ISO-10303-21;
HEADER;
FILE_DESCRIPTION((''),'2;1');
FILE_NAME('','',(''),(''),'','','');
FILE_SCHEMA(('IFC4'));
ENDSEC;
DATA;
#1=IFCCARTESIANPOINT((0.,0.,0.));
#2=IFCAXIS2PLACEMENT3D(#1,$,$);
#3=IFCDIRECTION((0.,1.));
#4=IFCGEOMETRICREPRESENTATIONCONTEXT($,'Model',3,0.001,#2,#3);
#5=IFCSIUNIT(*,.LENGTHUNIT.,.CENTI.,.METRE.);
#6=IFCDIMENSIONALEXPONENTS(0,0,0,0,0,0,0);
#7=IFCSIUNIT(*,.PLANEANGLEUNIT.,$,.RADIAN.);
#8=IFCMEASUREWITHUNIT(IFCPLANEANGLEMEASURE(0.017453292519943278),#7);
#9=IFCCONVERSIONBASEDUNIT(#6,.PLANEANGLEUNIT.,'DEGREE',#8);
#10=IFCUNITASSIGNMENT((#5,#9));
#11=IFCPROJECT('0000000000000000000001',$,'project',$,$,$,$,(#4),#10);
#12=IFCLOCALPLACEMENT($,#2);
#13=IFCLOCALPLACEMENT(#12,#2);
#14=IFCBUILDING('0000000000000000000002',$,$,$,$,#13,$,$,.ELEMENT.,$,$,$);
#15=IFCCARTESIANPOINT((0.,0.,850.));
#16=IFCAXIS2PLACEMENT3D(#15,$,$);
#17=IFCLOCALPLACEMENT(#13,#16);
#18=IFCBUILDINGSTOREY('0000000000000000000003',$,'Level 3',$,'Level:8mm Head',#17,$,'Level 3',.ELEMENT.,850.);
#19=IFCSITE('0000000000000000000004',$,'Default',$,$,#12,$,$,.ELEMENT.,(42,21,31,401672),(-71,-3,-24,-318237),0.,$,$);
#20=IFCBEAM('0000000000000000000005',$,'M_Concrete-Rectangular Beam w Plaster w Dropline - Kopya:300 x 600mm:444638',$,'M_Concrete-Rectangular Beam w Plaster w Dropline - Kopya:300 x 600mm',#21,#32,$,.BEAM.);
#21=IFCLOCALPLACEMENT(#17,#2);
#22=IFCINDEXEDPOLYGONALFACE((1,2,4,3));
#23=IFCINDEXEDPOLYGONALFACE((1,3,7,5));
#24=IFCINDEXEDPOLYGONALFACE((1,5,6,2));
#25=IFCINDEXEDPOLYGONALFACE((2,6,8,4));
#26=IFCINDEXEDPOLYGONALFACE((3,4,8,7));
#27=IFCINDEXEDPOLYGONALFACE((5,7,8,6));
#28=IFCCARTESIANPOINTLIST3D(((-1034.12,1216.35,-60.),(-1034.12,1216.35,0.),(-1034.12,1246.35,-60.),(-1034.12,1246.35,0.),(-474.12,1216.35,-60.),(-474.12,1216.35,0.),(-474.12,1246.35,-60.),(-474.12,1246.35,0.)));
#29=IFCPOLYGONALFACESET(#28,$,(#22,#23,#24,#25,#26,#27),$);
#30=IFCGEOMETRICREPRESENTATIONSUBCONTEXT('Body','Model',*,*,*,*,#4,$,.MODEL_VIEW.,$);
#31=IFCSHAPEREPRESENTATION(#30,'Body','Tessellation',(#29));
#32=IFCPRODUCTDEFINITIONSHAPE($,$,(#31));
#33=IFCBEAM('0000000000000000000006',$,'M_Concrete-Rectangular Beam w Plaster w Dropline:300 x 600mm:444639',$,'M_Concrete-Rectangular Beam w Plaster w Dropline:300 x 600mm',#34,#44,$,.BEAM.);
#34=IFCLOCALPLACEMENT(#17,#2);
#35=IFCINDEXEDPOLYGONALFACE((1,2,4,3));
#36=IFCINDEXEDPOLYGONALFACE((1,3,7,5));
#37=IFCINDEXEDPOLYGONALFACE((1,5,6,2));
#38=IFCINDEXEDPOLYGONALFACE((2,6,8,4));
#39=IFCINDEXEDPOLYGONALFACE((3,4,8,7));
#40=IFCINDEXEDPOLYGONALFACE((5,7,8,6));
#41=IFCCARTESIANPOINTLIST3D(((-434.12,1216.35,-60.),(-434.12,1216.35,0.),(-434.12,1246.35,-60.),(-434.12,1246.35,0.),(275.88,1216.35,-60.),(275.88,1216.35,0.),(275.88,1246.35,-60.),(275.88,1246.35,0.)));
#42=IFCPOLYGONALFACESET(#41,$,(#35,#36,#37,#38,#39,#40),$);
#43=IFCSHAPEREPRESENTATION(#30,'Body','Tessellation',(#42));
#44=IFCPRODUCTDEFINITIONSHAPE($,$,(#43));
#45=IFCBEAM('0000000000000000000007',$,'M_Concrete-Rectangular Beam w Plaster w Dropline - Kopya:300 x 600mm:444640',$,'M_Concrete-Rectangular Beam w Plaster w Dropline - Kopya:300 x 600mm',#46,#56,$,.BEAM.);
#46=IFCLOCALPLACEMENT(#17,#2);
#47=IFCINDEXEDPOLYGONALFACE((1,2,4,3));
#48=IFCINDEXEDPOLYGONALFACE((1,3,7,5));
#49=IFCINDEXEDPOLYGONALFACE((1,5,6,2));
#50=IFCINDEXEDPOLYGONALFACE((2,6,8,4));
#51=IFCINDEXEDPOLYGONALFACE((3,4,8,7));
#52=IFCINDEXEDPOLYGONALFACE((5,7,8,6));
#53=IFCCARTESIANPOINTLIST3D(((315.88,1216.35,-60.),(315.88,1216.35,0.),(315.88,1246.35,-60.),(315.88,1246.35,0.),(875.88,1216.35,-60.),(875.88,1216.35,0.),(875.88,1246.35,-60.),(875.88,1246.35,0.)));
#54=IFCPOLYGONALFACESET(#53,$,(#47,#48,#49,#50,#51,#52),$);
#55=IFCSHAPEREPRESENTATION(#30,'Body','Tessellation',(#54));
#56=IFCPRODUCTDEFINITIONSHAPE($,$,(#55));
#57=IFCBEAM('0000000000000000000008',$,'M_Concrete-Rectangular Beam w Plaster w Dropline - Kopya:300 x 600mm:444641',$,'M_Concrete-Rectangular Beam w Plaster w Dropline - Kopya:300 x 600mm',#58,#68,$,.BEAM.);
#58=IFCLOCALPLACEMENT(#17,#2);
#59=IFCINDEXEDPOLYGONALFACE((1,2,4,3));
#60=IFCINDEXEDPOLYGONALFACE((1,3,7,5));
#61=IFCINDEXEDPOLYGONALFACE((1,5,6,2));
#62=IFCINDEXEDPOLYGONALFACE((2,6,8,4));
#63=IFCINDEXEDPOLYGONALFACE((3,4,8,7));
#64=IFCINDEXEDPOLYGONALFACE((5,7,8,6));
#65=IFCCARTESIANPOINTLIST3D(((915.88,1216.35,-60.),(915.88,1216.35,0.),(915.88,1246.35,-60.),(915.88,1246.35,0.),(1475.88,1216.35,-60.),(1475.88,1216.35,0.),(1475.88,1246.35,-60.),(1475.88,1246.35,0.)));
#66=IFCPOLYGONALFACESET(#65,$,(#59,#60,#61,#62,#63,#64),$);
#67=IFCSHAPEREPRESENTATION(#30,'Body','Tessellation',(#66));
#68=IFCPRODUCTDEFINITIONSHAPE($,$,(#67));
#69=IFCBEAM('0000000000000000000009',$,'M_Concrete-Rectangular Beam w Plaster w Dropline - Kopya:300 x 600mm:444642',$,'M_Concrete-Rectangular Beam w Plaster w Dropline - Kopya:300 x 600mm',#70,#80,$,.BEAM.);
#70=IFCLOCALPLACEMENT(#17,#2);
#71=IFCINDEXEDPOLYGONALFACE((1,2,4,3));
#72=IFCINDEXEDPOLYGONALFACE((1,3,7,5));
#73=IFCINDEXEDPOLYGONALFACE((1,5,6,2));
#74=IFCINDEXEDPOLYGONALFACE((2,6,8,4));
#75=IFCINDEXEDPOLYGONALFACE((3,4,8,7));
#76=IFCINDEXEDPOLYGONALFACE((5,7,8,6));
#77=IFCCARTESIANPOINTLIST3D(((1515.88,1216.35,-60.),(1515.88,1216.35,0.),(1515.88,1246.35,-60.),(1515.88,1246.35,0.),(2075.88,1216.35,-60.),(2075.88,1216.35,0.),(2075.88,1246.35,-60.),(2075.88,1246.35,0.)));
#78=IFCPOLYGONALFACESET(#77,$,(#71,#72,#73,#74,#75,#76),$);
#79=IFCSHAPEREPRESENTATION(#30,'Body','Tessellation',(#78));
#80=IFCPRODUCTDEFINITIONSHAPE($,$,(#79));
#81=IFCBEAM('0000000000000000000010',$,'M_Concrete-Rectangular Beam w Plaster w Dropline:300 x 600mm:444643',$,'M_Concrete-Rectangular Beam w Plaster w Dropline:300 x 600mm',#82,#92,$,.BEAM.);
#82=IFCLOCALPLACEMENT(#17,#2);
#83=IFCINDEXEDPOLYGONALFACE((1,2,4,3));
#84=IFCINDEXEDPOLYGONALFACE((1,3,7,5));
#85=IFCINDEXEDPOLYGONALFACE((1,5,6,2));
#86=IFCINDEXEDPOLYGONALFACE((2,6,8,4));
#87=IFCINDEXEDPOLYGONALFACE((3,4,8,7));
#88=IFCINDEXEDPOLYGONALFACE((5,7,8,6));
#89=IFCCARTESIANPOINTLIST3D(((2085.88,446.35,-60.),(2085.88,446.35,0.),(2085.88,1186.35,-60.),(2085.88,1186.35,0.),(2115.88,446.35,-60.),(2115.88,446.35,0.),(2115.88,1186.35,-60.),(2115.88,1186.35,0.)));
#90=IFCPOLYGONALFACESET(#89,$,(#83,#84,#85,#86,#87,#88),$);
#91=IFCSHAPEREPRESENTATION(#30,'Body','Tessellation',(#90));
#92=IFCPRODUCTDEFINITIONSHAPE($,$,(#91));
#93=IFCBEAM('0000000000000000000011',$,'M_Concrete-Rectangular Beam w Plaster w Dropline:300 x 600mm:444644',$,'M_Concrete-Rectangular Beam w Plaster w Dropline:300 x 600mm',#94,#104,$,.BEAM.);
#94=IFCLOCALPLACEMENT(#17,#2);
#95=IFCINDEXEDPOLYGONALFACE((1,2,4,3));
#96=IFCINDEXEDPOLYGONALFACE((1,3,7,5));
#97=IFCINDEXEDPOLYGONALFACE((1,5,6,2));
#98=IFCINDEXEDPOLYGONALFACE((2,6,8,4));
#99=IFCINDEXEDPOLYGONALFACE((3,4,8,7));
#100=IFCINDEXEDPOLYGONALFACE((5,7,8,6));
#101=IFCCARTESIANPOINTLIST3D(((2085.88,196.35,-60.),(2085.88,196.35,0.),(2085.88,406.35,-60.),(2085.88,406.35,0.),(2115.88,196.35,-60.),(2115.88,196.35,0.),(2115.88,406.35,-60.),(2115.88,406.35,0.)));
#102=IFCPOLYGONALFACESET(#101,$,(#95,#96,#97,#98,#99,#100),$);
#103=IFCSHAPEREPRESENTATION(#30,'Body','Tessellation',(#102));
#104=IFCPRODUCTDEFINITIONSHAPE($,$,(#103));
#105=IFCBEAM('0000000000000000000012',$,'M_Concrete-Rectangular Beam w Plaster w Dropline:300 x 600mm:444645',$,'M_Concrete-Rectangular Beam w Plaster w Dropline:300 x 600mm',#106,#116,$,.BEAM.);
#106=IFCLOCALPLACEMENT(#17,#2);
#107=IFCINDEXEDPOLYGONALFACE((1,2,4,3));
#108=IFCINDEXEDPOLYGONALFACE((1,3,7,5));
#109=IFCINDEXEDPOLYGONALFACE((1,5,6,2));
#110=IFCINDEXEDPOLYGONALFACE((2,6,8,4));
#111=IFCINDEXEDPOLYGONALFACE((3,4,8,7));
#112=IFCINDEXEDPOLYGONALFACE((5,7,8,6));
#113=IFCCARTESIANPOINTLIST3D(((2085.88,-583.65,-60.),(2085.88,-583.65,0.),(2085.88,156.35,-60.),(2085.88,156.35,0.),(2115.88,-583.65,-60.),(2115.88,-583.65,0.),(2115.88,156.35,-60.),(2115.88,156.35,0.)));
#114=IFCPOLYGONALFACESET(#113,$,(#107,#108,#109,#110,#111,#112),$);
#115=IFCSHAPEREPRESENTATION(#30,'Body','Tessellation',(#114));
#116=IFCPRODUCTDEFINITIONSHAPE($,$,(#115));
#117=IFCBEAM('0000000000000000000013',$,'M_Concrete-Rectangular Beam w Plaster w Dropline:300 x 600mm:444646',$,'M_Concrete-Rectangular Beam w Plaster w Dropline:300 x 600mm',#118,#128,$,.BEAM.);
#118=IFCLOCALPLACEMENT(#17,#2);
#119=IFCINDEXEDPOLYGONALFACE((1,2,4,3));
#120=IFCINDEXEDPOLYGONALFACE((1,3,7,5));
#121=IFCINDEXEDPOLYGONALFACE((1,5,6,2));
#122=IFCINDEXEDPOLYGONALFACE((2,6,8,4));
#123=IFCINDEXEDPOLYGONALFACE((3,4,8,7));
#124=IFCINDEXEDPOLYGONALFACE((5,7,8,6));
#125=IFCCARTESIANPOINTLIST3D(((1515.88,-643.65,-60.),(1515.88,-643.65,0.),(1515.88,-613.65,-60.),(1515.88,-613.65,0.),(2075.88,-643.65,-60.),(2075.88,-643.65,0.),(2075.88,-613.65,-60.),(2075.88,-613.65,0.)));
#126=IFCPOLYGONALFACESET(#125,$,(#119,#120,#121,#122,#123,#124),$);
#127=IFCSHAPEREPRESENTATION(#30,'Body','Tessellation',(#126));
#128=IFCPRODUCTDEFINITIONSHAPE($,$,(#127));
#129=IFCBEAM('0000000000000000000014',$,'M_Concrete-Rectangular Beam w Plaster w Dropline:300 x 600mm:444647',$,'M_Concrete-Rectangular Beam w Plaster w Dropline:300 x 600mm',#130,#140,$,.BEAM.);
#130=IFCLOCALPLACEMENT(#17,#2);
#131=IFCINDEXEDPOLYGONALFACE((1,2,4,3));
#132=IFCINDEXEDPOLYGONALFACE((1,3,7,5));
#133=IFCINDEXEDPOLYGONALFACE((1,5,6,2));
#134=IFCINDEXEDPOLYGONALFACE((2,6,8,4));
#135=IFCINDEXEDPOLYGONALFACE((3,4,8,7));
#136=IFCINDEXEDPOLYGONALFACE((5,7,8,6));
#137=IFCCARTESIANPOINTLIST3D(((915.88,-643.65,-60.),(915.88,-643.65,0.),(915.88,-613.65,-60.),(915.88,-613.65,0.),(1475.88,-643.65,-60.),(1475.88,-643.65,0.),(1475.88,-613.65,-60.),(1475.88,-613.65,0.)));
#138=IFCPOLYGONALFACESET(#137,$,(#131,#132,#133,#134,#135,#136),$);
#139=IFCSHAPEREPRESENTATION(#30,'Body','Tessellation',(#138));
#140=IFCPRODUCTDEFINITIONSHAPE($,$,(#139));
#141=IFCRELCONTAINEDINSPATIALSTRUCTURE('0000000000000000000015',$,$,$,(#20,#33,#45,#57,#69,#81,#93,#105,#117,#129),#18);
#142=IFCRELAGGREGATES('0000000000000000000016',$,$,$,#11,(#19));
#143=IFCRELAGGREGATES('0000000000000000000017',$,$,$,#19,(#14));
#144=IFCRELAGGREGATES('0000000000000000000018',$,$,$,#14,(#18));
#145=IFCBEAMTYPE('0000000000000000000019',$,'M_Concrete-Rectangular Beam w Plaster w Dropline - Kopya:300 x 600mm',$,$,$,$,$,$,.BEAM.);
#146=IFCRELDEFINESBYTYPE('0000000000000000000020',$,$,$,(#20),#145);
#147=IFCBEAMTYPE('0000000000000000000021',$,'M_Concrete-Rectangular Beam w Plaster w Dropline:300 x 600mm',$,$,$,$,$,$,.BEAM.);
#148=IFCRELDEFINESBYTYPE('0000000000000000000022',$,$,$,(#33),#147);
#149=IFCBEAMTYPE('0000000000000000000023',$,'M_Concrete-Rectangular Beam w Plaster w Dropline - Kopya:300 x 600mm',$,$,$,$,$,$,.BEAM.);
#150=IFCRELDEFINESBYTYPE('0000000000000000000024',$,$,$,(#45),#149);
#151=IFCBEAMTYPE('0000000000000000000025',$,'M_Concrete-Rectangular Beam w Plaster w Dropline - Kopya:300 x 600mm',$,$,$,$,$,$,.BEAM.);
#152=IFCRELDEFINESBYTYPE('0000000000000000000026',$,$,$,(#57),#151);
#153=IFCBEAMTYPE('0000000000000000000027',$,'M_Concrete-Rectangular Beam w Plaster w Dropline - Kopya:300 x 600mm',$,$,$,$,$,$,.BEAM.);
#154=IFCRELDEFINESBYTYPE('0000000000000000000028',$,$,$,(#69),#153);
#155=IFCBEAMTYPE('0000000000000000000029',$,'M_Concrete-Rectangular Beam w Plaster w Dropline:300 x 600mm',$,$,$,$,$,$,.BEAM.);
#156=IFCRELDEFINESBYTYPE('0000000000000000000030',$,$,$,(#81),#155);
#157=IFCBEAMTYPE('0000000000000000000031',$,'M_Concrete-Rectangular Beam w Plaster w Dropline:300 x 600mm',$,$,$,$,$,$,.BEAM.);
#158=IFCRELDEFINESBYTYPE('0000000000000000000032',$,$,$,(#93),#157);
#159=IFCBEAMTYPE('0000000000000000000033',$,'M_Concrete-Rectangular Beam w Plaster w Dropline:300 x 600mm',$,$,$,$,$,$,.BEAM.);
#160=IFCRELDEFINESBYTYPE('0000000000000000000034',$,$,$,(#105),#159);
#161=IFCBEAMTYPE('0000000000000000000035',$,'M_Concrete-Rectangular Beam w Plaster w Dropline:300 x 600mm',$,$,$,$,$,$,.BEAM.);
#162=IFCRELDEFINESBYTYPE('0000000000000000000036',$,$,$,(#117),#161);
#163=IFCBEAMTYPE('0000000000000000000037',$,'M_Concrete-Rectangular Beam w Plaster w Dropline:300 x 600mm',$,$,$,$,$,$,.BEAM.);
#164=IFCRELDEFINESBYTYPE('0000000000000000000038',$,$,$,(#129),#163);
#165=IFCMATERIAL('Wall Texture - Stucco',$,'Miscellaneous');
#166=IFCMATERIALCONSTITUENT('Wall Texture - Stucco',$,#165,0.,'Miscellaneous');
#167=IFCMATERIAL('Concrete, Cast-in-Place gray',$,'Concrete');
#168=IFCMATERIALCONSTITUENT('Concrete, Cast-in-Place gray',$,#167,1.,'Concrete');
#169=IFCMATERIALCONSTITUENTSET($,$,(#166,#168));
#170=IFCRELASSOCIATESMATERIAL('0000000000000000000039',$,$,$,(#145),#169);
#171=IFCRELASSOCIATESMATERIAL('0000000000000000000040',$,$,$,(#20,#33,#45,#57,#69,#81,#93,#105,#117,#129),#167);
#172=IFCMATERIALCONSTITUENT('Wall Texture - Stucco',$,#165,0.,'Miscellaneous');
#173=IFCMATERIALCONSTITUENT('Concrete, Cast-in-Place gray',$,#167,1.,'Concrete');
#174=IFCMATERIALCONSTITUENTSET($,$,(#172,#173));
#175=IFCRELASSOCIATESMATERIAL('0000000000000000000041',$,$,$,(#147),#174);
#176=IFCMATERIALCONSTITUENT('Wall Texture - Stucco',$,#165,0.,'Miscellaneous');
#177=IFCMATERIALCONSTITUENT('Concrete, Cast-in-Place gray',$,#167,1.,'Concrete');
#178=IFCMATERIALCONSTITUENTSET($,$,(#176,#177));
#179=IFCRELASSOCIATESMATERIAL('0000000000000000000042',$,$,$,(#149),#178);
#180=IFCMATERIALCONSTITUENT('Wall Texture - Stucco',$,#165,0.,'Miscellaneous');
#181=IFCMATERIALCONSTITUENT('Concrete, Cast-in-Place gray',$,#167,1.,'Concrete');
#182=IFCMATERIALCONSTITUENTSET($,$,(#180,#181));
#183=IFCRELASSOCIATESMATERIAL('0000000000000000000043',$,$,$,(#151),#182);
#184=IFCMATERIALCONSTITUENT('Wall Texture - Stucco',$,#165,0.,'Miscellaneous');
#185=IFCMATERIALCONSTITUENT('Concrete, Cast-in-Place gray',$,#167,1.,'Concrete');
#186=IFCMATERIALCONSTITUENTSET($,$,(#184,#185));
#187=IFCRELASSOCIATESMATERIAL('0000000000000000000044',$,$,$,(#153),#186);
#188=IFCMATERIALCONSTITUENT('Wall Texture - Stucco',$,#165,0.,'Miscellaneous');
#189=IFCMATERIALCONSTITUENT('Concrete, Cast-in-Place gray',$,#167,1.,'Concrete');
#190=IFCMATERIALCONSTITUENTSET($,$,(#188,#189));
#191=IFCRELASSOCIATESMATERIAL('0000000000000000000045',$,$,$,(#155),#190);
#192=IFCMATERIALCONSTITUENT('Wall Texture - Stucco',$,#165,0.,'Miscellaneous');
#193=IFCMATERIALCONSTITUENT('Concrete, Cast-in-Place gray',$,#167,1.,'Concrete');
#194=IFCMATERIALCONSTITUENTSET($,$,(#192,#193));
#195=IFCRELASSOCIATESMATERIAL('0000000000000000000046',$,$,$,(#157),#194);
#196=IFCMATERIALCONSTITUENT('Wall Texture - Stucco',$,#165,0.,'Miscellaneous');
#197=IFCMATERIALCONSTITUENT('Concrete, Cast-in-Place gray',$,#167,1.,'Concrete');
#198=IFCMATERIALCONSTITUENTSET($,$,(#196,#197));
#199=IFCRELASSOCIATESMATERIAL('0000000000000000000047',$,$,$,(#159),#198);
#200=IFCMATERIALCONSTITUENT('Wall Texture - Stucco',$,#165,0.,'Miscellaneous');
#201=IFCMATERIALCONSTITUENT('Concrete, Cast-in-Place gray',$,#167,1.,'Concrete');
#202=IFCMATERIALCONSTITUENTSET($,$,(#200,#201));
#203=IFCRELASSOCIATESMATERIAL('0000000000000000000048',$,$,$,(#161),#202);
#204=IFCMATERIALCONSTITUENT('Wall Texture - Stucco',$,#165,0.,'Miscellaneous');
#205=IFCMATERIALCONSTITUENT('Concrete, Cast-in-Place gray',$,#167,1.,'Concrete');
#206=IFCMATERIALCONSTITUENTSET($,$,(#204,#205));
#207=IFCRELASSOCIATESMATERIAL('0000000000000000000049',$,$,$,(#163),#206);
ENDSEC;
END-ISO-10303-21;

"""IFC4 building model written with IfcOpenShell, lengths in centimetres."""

from ifc_helpers import new_model, entity, si_unit, converted_unit, direction, frame, origin, place, context, subcontext, project, spatial, indexed_curve, outline, extrude, source, transform, mapped, material, constituent, constituent_set, type_object, type_shapes, element, save


model = new_model("IFC4")

# Units and contexts
model_context = context("Model", 3, precision=0.001, world=origin(), true_north=direction((0.0, 1.0)))
body_context = subcontext(model_context, "Body", "Model", "MODEL_VIEW")
ifc_project = project(units=[si_unit("LENGTHUNIT", "METRE", prefix="CENTI"), converted_unit("PLANEANGLEUNIT", "DEGREE", entity("IfcPlaneAngleMeasure", 0.017453292519943278), si_unit("PLANEANGLEUNIT", "RADIAN"), dimensions=[0, 0, 0, 0, 0, 0, 0])], contexts=[model_context])

# Site, building, storey
site_placement = place(None, origin())
site = spatial("IfcSite", under=ifc_project, at=site_placement, Name="Default", CompositionType="ELEMENT", RefLatitude=(42, 21, 31, 401672), RefLongitude=(-71, -3, -24, -318237), RefElevation=0.0)
building_placement = place(site_placement, origin())
building = spatial("IfcBuilding", under=site, at=building_placement, CompositionType="ELEMENT")
storey_placement = place(building_placement, frame((0.0, 0.0, 850.0)))
storey = spatial("IfcBuildingStorey", under=building, at=storey_placement, Name="Level 3", ObjectType="Level:8mm Head", LongName="Level 3", CompositionType="ELEMENT", Elevation=850.0)

# Beams
ifc_material_1 = material(Name="Concrete, Cast-in-Place gray", Category="Concrete")
ifc_material_2 = material(Name="Wall Texture - Stucco", Category="Miscellaneous")
ifc_constituent_1 = constituent(ifc_material_2, Name="Wall Texture - Stucco", Category="Miscellaneous", fraction=0.0)
ifc_constituent_2 = constituent(ifc_material_1, Name="Concrete, Cast-in-Place gray", Category="Concrete", fraction=1.0)
ifc_constituent_set_1 = constituent_set(constituents=[ifc_constituent_1, ifc_constituent_2])
beam_type_1 = type_object("IfcBeamType", Name="M_Concrete-Rectangular Beam w Plaster w Dropline - Kopya:300 x 600mm", PredefinedType="BEAM", material=ifc_constituent_set_1)
shared_shape_1 = source(origin(), body_context, "Body", "SweptSolid", [
    extrude(outline(indexed_curve([(-30.0, -15.0), (30.0, -15.0), (30.0, 15.0), (-30.0, 15.0), (-30.0, -15.0)], self_intersect=False)), frame((-1034.12, 1231.35, 820.0), z_axis=(1.0, 0.0, 0.0), x_axis=(0.0, 0.0, -1.0)), (0.0, 0.0, 1.0), 560.0),
])
type_shapes(beam_type_1, [shared_shape_1])
beam_1_placement = place(storey_placement, frame((0.0, 0.0, -850.0)))
element("IfcBeam", 1, at=beam_1_placement, inside=storey, type_object=beam_type_1, material=ifc_material_1, Name="M_Concrete-Rectangular Beam w Plaster w Dropline - Kopya:300 x 600mm:444638", ObjectType="M_Concrete-Rectangular Beam w Plaster w Dropline - Kopya:300 x 600mm", PredefinedType="BEAM", context=body_context, shape_type="MappedRepresentation", body=[
    mapped(shared_shape_1, transform((0.0, 0.0, 0.0), scale=1.0)),
])
ifc_constituent_3 = constituent(ifc_material_2, Name="Wall Texture - Stucco", Category="Miscellaneous", fraction=0.0)
ifc_constituent_4 = constituent(ifc_material_1, Name="Concrete, Cast-in-Place gray", Category="Concrete", fraction=1.0)
ifc_constituent_set_2 = constituent_set(constituents=[ifc_constituent_3, ifc_constituent_4])
beam_type_2 = type_object("IfcBeamType", Name="M_Concrete-Rectangular Beam w Plaster w Dropline:300 x 600mm", PredefinedType="BEAM", material=ifc_constituent_set_2)
shared_shape_2 = source(origin(), body_context, "Body", "SweptSolid", [
    extrude(outline(indexed_curve([(-30.0, -15.0), (30.0, -15.0), (30.0, 15.0), (-30.0, 15.0), (-30.0, -15.0)], self_intersect=False)), frame((-434.12, 1231.35, 820.0), z_axis=(1.0, 0.0, 0.0), x_axis=(0.0, 0.0, -1.0)), (0.0, 0.0, 1.0), 710.0),
])
type_shapes(beam_type_2, [shared_shape_2])
beam_2_placement = place(storey_placement, frame((0.0, 0.0, -850.0)))
element("IfcBeam", 2, at=beam_2_placement, inside=storey, type_object=beam_type_2, material=ifc_material_1, Name="M_Concrete-Rectangular Beam w Plaster w Dropline:300 x 600mm:444639", ObjectType="M_Concrete-Rectangular Beam w Plaster w Dropline:300 x 600mm", PredefinedType="BEAM", context=body_context, shape_type="MappedRepresentation", body=[
    mapped(shared_shape_2, transform((0.0, 0.0, 0.0), scale=1.0)),
])
ifc_constituent_5 = constituent(ifc_material_2, Name="Wall Texture - Stucco", Category="Miscellaneous", fraction=0.0)
ifc_constituent_6 = constituent(ifc_material_1, Name="Concrete, Cast-in-Place gray", Category="Concrete", fraction=1.0)
ifc_constituent_set_3 = constituent_set(constituents=[ifc_constituent_5, ifc_constituent_6])
beam_type_3 = type_object("IfcBeamType", Name="M_Concrete-Rectangular Beam w Plaster w Dropline - Kopya:300 x 600mm", PredefinedType="BEAM", material=ifc_constituent_set_3)
shared_shape_3 = source(origin(), body_context, "Body", "SweptSolid", [
    extrude(outline(indexed_curve([(-30.0, -15.0), (30.0, -15.0), (30.0, 15.0), (-30.0, 15.0), (-30.0, -15.0)], self_intersect=False)), frame((315.88, 1231.35, 820.0), z_axis=(1.0, 0.0, 0.0), x_axis=(0.0, 0.0, -1.0)), (0.0, 0.0, 1.0), 560.0),
])
type_shapes(beam_type_3, [shared_shape_3])
beam_3_placement = place(storey_placement, frame((0.0, 0.0, -850.0)))
element("IfcBeam", 3, at=beam_3_placement, inside=storey, type_object=beam_type_3, material=ifc_material_1, Name="M_Concrete-Rectangular Beam w Plaster w Dropline - Kopya:300 x 600mm:444640", ObjectType="M_Concrete-Rectangular Beam w Plaster w Dropline - Kopya:300 x 600mm", PredefinedType="BEAM", context=body_context, shape_type="MappedRepresentation", body=[
    mapped(shared_shape_3, transform((0.0, 0.0, 0.0), scale=1.0)),
])
ifc_constituent_7 = constituent(ifc_material_2, Name="Wall Texture - Stucco", Category="Miscellaneous", fraction=0.0)
ifc_constituent_8 = constituent(ifc_material_1, Name="Concrete, Cast-in-Place gray", Category="Concrete", fraction=1.0)
ifc_constituent_set_4 = constituent_set(constituents=[ifc_constituent_7, ifc_constituent_8])
beam_type_4 = type_object("IfcBeamType", Name="M_Concrete-Rectangular Beam w Plaster w Dropline - Kopya:300 x 600mm", PredefinedType="BEAM", material=ifc_constituent_set_4)
shared_shape_4 = source(origin(), body_context, "Body", "SweptSolid", [
    extrude(outline(indexed_curve([(-30.0, -15.0), (30.0, -15.0), (30.0, 15.0), (-30.0, 15.0), (-30.0, -15.0)], self_intersect=False)), frame((915.88, 1231.35, 820.0), z_axis=(1.0, 0.0, 0.0), x_axis=(0.0, 0.0, -1.0)), (0.0, 0.0, 1.0), 560.0),
])
type_shapes(beam_type_4, [shared_shape_4])
beam_4_placement = place(storey_placement, frame((0.0, 0.0, -850.0)))
element("IfcBeam", 4, at=beam_4_placement, inside=storey, type_object=beam_type_4, material=ifc_material_1, Name="M_Concrete-Rectangular Beam w Plaster w Dropline - Kopya:300 x 600mm:444641", ObjectType="M_Concrete-Rectangular Beam w Plaster w Dropline - Kopya:300 x 600mm", PredefinedType="BEAM", context=body_context, shape_type="MappedRepresentation", body=[
    mapped(shared_shape_4, transform((0.0, 0.0, 0.0), scale=1.0)),
])
ifc_constituent_9 = constituent(ifc_material_2, Name="Wall Texture - Stucco", Category="Miscellaneous", fraction=0.0)
ifc_constituent_10 = constituent(ifc_material_1, Name="Concrete, Cast-in-Place gray", Category="Concrete", fraction=1.0)
ifc_constituent_set_5 = constituent_set(constituents=[ifc_constituent_9, ifc_constituent_10])
beam_type_5 = type_object("IfcBeamType", Name="M_Concrete-Rectangular Beam w Plaster w Dropline - Kopya:300 x 600mm", PredefinedType="BEAM", material=ifc_constituent_set_5)
shared_shape_5 = source(origin(), body_context, "Body", "SweptSolid", [
    extrude(outline(indexed_curve([(-30.0, -15.0), (30.0, -15.0), (30.0, 15.0), (-30.0, 15.0), (-30.0, -15.0)], self_intersect=False)), frame((1515.88, 1231.35, 820.0), z_axis=(1.0, 0.0, 0.0), x_axis=(0.0, 0.0, -1.0)), (0.0, 0.0, 1.0), 560.0),
])
type_shapes(beam_type_5, [shared_shape_5])
beam_5_placement = place(storey_placement, frame((0.0, 0.0, -850.0)))
element("IfcBeam", 5, at=beam_5_placement, inside=storey, type_object=beam_type_5, material=ifc_material_1, Name="M_Concrete-Rectangular Beam w Plaster w Dropline - Kopya:300 x 600mm:444642", ObjectType="M_Concrete-Rectangular Beam w Plaster w Dropline - Kopya:300 x 600mm", PredefinedType="BEAM", context=body_context, shape_type="MappedRepresentation", body=[
    mapped(shared_shape_5, transform((0.0, 0.0, 0.0), scale=1.0)),
])
ifc_constituent_11 = constituent(ifc_material_2, Name="Wall Texture - Stucco", Category="Miscellaneous", fraction=0.0)
ifc_constituent_12 = constituent(ifc_material_1, Name="Concrete, Cast-in-Place gray", Category="Concrete", fraction=1.0)
ifc_constituent_set_6 = constituent_set(constituents=[ifc_constituent_11, ifc_constituent_12])
beam_type_6 = type_object("IfcBeamType", Name="M_Concrete-Rectangular Beam w Plaster w Dropline:300 x 600mm", PredefinedType="BEAM", material=ifc_constituent_set_6)
shared_shape_6 = source(origin(), body_context, "Body", "SweptSolid", [
    extrude(outline(indexed_curve([(-15.0, -30.0), (15.0, -30.0), (15.0, 30.0), (-15.0, 30.0), (-15.0, -30.0)], self_intersect=False)), frame((2100.88, 1186.35, 820.0), z_axis=(0.0, -1.0, 0.0), x_axis=(-1.0, 0.0, 0.0)), (0.0, 0.0, 1.0), 740.0),
])
type_shapes(beam_type_6, [shared_shape_6])
beam_6_placement = place(storey_placement, frame((0.0, 0.0, -850.0)))
element("IfcBeam", 6, at=beam_6_placement, inside=storey, type_object=beam_type_6, material=ifc_material_1, Name="M_Concrete-Rectangular Beam w Plaster w Dropline:300 x 600mm:444643", ObjectType="M_Concrete-Rectangular Beam w Plaster w Dropline:300 x 600mm", PredefinedType="BEAM", context=body_context, shape_type="MappedRepresentation", body=[
    mapped(shared_shape_6, transform((0.0, 0.0, 0.0), scale=1.0)),
])
ifc_constituent_13 = constituent(ifc_material_2, Name="Wall Texture - Stucco", Category="Miscellaneous", fraction=0.0)
ifc_constituent_14 = constituent(ifc_material_1, Name="Concrete, Cast-in-Place gray", Category="Concrete", fraction=1.0)
ifc_constituent_set_7 = constituent_set(constituents=[ifc_constituent_13, ifc_constituent_14])
beam_type_7 = type_object("IfcBeamType", Name="M_Concrete-Rectangular Beam w Plaster w Dropline:300 x 600mm", PredefinedType="BEAM", material=ifc_constituent_set_7)
shared_shape_7 = source(origin(), body_context, "Body", "SweptSolid", [
    extrude(outline(indexed_curve([(-15.0, -30.0), (15.0, -30.0), (15.0, 30.0), (-15.0, 30.0), (-15.0, -30.0)], self_intersect=False)), frame((2100.88, 406.35, 820.0), z_axis=(0.0, -1.0, 0.0), x_axis=(-1.0, 0.0, 0.0)), (0.0, 0.0, 1.0), 210.0),
])
type_shapes(beam_type_7, [shared_shape_7])
beam_7_placement = place(storey_placement, frame((0.0, 0.0, -850.0)))
element("IfcBeam", 7, at=beam_7_placement, inside=storey, type_object=beam_type_7, material=ifc_material_1, Name="M_Concrete-Rectangular Beam w Plaster w Dropline:300 x 600mm:444644", ObjectType="M_Concrete-Rectangular Beam w Plaster w Dropline:300 x 600mm", PredefinedType="BEAM", context=body_context, shape_type="MappedRepresentation", body=[
    mapped(shared_shape_7, transform((0.0, 0.0, 0.0), scale=1.0)),
])
ifc_constituent_15 = constituent(ifc_material_2, Name="Wall Texture - Stucco", Category="Miscellaneous", fraction=0.0)
ifc_constituent_16 = constituent(ifc_material_1, Name="Concrete, Cast-in-Place gray", Category="Concrete", fraction=1.0)
ifc_constituent_set_8 = constituent_set(constituents=[ifc_constituent_15, ifc_constituent_16])
beam_type_8 = type_object("IfcBeamType", Name="M_Concrete-Rectangular Beam w Plaster w Dropline:300 x 600mm", PredefinedType="BEAM", material=ifc_constituent_set_8)
shared_shape_8 = source(origin(), body_context, "Body", "SweptSolid", [
    extrude(outline(indexed_curve([(-15.0, -30.0), (15.0, -30.0), (15.0, 30.0), (-15.0, 30.0), (-15.0, -30.0)], self_intersect=False)), frame((2100.88, 156.35, 820.0), z_axis=(0.0, -1.0, 0.0), x_axis=(-1.0, 0.0, 0.0)), (0.0, 0.0, 1.0), 740.0),
])
type_shapes(beam_type_8, [shared_shape_8])
beam_8_placement = place(storey_placement, frame((0.0, 0.0, -850.0)))
element("IfcBeam", 8, at=beam_8_placement, inside=storey, type_object=beam_type_8, material=ifc_material_1, Name="M_Concrete-Rectangular Beam w Plaster w Dropline:300 x 600mm:444645", ObjectType="M_Concrete-Rectangular Beam w Plaster w Dropline:300 x 600mm", PredefinedType="BEAM", context=body_context, shape_type="MappedRepresentation", body=[
    mapped(shared_shape_8, transform((0.0, 0.0, 0.0), scale=1.0)),
])
ifc_constituent_17 = constituent(ifc_material_2, Name="Wall Texture - Stucco", Category="Miscellaneous", fraction=0.0)
ifc_constituent_18 = constituent(ifc_material_1, Name="Concrete, Cast-in-Place gray", Category="Concrete", fraction=1.0)
ifc_constituent_set_9 = constituent_set(constituents=[ifc_constituent_17, ifc_constituent_18])
beam_type_9 = type_object("IfcBeamType", Name="M_Concrete-Rectangular Beam w Plaster w Dropline:300 x 600mm", PredefinedType="BEAM", material=ifc_constituent_set_9)
shared_shape_9 = source(origin(), body_context, "Body", "SweptSolid", [
    extrude(outline(indexed_curve([(-30.0, -15.0), (30.0, -15.0), (30.0, 15.0), (-30.0, 15.0), (-30.0, -15.0)], self_intersect=False)), frame((2075.88, -628.65, 820.0), z_axis=(-1.0, 0.0, 0.0), x_axis=(0.0, 0.0, -1.0)), (0.0, 0.0, 1.0), 560.0),
])
type_shapes(beam_type_9, [shared_shape_9])
beam_9_placement = place(storey_placement, frame((0.0, 0.0, -850.0)))
element("IfcBeam", 9, at=beam_9_placement, inside=storey, type_object=beam_type_9, material=ifc_material_1, Name="M_Concrete-Rectangular Beam w Plaster w Dropline:300 x 600mm:444646", ObjectType="M_Concrete-Rectangular Beam w Plaster w Dropline:300 x 600mm", PredefinedType="BEAM", context=body_context, shape_type="MappedRepresentation", body=[
    mapped(shared_shape_9, transform((0.0, 0.0, 0.0), scale=1.0)),
])
ifc_constituent_19 = constituent(ifc_material_2, Name="Wall Texture - Stucco", Category="Miscellaneous", fraction=0.0)
ifc_constituent_20 = constituent(ifc_material_1, Name="Concrete, Cast-in-Place gray", Category="Concrete", fraction=1.0)
ifc_constituent_set_10 = constituent_set(constituents=[ifc_constituent_19, ifc_constituent_20])
beam_type_10 = type_object("IfcBeamType", Name="M_Concrete-Rectangular Beam w Plaster w Dropline:300 x 600mm", PredefinedType="BEAM", material=ifc_constituent_set_10)
shared_shape_10 = source(origin(), body_context, "Body", "SweptSolid", [
    extrude(outline(indexed_curve([(-30.0, -15.0), (30.0, -15.0), (30.0, 15.0), (-30.0, 15.0), (-30.0, -15.0)], self_intersect=False)), frame((1475.88, -628.65, 820.0), z_axis=(-1.0, 0.0, 0.0), x_axis=(0.0, 0.0, -1.0)), (0.0, 0.0, 1.0), 560.0),
])
type_shapes(beam_type_10, [shared_shape_10])
beam_10_placement = place(storey_placement, frame((0.0, 0.0, -850.0)))
element("IfcBeam", 10, at=beam_10_placement, inside=storey, type_object=beam_type_10, material=ifc_material_1, Name="M_Concrete-Rectangular Beam w Plaster w Dropline:300 x 600mm:444647", ObjectType="M_Concrete-Rectangular Beam w Plaster w Dropline:300 x 600mm", PredefinedType="BEAM", context=body_context, shape_type="MappedRepresentation", body=[
    mapped(shared_shape_10, transform((0.0, 0.0, 0.0), scale=1.0)),
])

save(model, "model.ifc")
